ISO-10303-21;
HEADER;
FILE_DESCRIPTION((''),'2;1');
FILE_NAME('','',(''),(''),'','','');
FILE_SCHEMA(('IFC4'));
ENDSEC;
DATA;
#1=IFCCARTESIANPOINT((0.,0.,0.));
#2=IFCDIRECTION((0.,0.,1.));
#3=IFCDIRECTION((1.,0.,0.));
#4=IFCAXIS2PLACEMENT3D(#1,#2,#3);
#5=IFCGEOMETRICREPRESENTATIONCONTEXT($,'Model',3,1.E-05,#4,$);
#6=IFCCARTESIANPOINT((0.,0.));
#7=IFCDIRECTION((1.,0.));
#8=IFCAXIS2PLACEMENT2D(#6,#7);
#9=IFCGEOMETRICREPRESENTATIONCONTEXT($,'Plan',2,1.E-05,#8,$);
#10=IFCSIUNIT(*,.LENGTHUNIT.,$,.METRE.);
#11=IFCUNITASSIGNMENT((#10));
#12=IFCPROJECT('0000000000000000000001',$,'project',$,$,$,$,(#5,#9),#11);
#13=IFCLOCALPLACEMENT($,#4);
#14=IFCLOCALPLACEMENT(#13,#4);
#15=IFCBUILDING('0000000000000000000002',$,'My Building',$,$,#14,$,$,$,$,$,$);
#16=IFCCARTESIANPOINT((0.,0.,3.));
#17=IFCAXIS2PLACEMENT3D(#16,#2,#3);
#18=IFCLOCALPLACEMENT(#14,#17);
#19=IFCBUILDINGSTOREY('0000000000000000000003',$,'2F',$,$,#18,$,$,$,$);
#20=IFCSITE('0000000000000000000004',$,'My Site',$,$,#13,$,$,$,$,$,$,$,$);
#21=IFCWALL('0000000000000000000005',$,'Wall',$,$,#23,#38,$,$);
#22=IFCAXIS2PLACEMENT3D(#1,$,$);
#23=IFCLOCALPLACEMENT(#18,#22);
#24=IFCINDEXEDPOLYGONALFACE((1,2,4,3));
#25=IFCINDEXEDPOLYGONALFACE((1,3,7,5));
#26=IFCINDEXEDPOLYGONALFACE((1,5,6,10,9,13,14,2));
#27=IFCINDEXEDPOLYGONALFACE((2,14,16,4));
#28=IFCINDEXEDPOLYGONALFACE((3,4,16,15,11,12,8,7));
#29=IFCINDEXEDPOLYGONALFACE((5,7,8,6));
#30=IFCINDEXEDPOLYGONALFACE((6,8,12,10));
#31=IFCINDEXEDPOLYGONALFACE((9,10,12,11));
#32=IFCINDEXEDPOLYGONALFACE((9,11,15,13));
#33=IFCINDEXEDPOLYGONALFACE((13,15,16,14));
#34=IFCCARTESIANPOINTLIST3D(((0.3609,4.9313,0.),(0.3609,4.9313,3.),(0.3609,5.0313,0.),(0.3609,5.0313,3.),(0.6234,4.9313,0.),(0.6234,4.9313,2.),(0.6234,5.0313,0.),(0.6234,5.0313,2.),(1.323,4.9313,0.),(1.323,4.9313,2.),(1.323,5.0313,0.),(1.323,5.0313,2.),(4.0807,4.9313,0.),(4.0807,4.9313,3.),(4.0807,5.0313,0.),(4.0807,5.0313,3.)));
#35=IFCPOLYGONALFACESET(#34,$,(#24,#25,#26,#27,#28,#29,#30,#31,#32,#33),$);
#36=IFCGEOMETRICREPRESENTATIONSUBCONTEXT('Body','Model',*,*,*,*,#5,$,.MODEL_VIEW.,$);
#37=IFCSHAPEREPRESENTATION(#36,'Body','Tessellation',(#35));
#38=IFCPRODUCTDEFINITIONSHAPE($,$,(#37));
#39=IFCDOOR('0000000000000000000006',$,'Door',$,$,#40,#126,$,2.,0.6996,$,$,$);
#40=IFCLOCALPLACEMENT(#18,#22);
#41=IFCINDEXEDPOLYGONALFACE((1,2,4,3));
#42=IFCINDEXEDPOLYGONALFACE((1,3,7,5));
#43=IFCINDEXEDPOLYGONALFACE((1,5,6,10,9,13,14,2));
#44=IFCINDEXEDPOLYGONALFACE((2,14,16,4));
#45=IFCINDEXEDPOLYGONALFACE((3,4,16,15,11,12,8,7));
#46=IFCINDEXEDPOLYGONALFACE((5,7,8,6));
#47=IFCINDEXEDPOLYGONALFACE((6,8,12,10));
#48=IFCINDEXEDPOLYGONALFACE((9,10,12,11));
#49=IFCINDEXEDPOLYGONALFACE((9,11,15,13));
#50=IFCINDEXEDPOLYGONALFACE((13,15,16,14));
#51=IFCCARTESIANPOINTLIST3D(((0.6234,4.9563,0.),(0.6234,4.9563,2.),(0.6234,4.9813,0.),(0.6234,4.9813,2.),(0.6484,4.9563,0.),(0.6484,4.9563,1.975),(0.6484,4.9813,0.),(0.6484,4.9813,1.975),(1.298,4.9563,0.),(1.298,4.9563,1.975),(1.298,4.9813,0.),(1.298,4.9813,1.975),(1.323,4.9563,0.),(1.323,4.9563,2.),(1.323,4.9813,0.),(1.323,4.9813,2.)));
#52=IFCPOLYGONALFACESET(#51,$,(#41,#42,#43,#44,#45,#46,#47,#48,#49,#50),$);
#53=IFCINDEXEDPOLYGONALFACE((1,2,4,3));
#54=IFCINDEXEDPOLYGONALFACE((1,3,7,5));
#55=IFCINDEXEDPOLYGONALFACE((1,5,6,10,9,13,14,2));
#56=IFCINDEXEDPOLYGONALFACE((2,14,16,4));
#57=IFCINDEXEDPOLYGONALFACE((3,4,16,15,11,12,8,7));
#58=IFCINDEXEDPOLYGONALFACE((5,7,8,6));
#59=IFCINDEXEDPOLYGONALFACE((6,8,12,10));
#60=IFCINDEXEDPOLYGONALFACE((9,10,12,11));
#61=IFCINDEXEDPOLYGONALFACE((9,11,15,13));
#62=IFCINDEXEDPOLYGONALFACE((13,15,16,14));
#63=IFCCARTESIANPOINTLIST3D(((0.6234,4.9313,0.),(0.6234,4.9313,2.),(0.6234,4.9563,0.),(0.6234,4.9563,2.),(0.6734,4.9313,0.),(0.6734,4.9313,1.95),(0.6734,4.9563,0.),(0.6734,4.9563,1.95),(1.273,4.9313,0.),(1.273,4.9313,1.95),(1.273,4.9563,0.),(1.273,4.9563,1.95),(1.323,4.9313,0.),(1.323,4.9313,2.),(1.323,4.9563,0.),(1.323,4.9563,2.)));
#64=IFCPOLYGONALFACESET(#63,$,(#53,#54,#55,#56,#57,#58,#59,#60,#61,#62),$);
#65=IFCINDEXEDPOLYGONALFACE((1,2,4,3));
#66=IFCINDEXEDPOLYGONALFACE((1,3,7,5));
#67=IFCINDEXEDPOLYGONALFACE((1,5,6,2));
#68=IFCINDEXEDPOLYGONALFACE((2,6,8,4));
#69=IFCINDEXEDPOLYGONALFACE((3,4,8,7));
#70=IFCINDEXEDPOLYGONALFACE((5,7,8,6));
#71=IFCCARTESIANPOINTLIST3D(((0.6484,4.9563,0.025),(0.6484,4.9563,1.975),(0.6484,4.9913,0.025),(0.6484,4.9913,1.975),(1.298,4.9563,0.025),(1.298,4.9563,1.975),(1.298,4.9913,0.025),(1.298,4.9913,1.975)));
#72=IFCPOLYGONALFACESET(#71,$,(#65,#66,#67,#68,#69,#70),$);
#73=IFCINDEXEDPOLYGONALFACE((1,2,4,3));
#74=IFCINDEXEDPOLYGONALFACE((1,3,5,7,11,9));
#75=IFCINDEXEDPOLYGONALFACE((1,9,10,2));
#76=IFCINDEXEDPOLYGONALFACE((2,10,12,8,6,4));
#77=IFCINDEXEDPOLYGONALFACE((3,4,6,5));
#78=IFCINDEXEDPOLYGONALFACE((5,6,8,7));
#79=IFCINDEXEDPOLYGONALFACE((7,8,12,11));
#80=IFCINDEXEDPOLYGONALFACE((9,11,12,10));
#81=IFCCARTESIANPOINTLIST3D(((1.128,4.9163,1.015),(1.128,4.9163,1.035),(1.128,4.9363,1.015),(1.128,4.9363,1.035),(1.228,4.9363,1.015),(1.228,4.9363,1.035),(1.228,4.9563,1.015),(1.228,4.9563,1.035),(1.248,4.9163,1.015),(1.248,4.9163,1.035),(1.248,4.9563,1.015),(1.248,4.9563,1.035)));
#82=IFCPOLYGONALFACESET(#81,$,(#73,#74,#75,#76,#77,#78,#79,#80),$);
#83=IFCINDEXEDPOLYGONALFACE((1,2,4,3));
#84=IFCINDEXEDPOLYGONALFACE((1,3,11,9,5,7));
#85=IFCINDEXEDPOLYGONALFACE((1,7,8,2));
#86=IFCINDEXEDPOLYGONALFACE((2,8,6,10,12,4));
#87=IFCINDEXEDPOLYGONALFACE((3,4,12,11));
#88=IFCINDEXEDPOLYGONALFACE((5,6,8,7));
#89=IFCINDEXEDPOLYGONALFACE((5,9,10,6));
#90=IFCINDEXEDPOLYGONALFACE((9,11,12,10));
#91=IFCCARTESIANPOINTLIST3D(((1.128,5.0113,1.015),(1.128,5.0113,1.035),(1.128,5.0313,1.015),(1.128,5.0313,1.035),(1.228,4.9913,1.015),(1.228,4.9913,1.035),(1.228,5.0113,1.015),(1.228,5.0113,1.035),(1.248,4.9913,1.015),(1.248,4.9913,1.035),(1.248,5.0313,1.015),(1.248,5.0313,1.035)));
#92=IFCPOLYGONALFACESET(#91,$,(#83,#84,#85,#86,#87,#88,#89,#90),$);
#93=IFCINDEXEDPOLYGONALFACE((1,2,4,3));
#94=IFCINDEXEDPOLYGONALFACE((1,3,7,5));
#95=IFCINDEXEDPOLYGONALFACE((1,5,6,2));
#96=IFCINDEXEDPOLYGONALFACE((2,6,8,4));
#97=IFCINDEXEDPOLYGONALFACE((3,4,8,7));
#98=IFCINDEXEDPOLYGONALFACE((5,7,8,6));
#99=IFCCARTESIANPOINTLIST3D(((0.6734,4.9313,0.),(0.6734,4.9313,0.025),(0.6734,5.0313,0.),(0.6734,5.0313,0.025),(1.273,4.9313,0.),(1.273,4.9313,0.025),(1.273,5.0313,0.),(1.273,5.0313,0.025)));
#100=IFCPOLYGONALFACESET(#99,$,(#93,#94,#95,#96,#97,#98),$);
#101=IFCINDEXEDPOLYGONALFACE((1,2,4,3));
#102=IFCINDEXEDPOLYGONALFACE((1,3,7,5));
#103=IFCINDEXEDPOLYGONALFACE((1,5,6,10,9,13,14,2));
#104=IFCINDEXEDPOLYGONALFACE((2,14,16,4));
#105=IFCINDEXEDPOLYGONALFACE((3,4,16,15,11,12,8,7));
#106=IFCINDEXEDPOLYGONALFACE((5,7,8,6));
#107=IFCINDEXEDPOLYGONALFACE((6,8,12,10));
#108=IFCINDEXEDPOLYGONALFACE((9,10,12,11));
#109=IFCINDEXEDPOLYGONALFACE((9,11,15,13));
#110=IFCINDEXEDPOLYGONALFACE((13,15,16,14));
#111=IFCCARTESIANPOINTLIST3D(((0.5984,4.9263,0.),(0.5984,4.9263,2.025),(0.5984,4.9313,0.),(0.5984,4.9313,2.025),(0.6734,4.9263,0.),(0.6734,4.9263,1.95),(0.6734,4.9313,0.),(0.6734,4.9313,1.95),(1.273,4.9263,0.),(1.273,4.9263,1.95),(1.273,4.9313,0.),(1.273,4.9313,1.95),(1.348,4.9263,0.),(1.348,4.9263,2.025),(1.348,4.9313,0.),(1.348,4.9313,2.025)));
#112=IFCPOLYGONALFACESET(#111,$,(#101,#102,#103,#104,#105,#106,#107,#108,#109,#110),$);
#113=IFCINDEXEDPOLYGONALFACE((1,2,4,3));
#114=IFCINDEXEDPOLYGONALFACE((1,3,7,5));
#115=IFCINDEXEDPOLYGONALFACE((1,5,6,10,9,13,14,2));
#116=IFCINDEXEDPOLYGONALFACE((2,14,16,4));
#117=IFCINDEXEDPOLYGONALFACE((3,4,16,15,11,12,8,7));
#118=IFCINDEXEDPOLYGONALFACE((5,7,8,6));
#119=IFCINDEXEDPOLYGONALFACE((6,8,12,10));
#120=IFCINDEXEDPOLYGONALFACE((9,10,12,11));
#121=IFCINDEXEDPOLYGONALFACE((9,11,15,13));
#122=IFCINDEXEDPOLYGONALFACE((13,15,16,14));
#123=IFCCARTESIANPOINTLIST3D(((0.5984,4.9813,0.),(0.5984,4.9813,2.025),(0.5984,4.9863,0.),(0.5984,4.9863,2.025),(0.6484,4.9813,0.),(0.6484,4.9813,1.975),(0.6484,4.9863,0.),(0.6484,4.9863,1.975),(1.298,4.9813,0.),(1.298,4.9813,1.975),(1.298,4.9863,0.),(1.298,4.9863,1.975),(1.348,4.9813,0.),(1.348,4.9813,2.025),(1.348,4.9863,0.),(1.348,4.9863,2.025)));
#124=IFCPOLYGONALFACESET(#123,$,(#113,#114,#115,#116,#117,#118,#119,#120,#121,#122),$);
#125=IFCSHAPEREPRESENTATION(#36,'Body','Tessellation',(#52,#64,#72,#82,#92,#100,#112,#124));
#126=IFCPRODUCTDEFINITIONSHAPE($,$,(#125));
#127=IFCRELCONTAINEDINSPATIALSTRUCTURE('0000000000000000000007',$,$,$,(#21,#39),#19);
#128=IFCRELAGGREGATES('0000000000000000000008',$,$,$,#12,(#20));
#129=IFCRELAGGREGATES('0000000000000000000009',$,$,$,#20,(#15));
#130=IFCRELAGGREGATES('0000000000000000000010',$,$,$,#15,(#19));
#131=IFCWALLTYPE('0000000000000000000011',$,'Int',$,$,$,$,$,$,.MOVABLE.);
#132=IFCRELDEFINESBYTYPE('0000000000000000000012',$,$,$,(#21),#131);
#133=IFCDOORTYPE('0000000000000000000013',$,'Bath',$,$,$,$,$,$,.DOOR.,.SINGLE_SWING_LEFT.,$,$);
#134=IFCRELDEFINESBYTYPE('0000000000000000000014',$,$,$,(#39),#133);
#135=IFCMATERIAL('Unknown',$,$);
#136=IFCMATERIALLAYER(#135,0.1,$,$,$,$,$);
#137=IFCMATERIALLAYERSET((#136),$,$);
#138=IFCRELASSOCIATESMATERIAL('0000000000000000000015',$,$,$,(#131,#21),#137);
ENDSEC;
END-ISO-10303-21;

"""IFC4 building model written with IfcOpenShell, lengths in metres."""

from ifc_helpers import new_model, entity, si_unit, frame, origin_with_axes, origin_2d_with_axis, place, context, subcontext, project, spatial, line, indexed_curve, outline, extrude, shape, source, transform, mapped, material, layer, layer_set, layer_usage, type_object, type_shapes, element, fill, save


model = new_model("IFC4")

# Units and contexts
model_context = context("Model", 3, precision=1e-05, world=origin_with_axes())
plan_context = context("Plan", 2, precision=1e-05, world=origin_2d_with_axis())
body_context_1 = subcontext(model_context, "Body", "Model", "MODEL_VIEW")
body_context_2 = subcontext(plan_context, "Body", "Plan", "PLAN_VIEW")
ifc_project = project(units=[si_unit("LENGTHUNIT", "METRE")], contexts=[model_context, plan_context])

# Site, building, storey
site_placement = place(None, origin_with_axes())
site = spatial("IfcSite", under=ifc_project, at=site_placement, Name="My Site")
building_placement = place(site_placement, origin_with_axes())
building = spatial("IfcBuilding", under=site, at=building_placement, Name="My Building")
storey_placement = place(building_placement, frame((0.0, 0.0, 3.0), z_axis=(0.0, 0.0, 1.0), x_axis=(1.0, 0.0, 0.0)))
storey = spatial("IfcBuildingStorey", under=building, at=storey_placement, Name="2F")

# Shared definitions
ifc_material = material(Name="Unknown")

# Shared definitions
ifc_layer_1 = layer(ifc_material, 0.1)
ifc_layer_set_1 = layer_set([ifc_layer_1])
wall_type_1 = type_object("IfcWallType", Name="Int", PredefinedType="MOVABLE", material=ifc_layer_set_1)

# Wall, opening, door
ifc_layer_usage_1 = layer_usage(ifc_layer_set_1, "AXIS2", "POSITIVE", 0.0)
wall_1_placement = place(storey_placement, frame((4.0807, 5.0313, 0.0), z_axis=(0.0, 0.0, 1.0), x_axis=(-1.0, 0.0, 0.0)))
wall_1 = element("IfcWall", 1, at=wall_1_placement, inside=storey, type_object=wall_type_1, material=ifc_layer_usage_1, Name="Wall", context=body_context_1, shape_type="SweptSolid", body=[
    extrude(outline(indexed_curve([(0.0, 0.0), (0.0, 0.1), (3.7198, 0.1), (3.7198, 0.0)], segments=[line(1, 2, 3, 4, 1)])), origin_with_axes(), (0.0, 0.0, 1.0), 3.0),
])
shared_shape_1 = source(origin_with_axes(), body_context_1, "Body", "SweptSolid", [
    extrude(outline(indexed_curve([(0.0, 0.0), (0.6996, 0.0), (0.6996, 2.0), (0.0, 2.0)], segments=[line(1, 2, 3, 4, 1)])), frame((0.0, -0.6, 0.0), z_axis=(0.0, -1.0, 0.0), x_axis=(1.0, 0.0, 0.0)), (0.0, 0.0, -1.0), 1.2),
])
opening_1_placement = place(wall_1_placement, frame((3.4573, 0.1, 0.0), z_axis=(0.0, 0.0, 1.0), x_axis=(-1.0, 0.0, 0.0)))
opening_1 = element("IfcOpeningElement", 2, at=opening_1_placement, cuts=wall_1, PredefinedType="OPENING", context=body_context_1, shape_type="MappedRepresentation", body=[
    mapped(shared_shape_1, transform((0.0, 0.0, 0.0), x_axis=(1.0, 0.0, 0.0), y_axis=(0.0, 1.0, 0.0), z_axis=(0.0, 0.0, 1.0), scale=1.0)),
])
door_type_1 = type_object("IfcDoorType", Name="Bath", OperationType="SINGLE_SWING_LEFT", PredefinedType="DOOR")
shared_shape_2 = source(origin_with_axes(), body_context_1, "Body", "SweptSolid", [
    extrude(outline(indexed_curve([(0.025, 0.0), (0.025, 1.975), (0.6746, 1.975), (0.6746, 0.0), (0.6996, 0.0), (0.6996, 2.0), (0.0, 2.0), (0.0, 0.0), (0.025, 0.0)])), frame((0.0, 0.025, 0.0), z_axis=(0.0, -1.0, 0.0), x_axis=(1.0, 0.0, 0.0)), (0.0, 0.0, -1.0), 0.025),
    extrude(outline(indexed_curve([(0.0, 0.0), (0.0, 2.0), (0.6996, 2.0), (0.6996, 0.0), (0.6496, 0.0), (0.6496, 1.95), (0.05, 1.95), (0.05, 0.0)], segments=[line(1, 2, 3, 4, 5, 6, 7, 8, 1)])), frame((0.0, 0.0, 0.0), z_axis=(0.0, -1.0, 0.0), x_axis=(1.0, 0.0, 0.0)), (0.0, 0.0, -1.0), 0.025),
    extrude(outline(indexed_curve([(0.0, 0.0), (0.6496, 0.0), (0.6496, 0.035), (0.0, 0.035)], segments=[line(1, 2, 3, 4, 1)])), frame((0.025, 0.025, 0.025), z_axis=(0.0, 0.0, 1.0), x_axis=(1.0, 0.0, 0.0)), (0.0, 0.0, 1.0), 1.95),
    extrude(outline(indexed_curve([(0.0, 0.0), (0.0, -0.04), (-0.12, -0.04), (-0.12, -0.02), (-0.02, -0.02), (-0.02, 0.0)], segments=[line(1, 2, 3, 4, 5, 6, 1)])), frame((0.6246, 0.025, 1.015), z_axis=(0.0, 0.0, 1.0), x_axis=(1.0, 0.0, 0.0)), (0.0, 0.0, 1.0), 0.02),
    extrude(outline(indexed_curve([(0.0, 0.0), (0.0, 0.04), (-0.12, 0.04), (-0.12, 0.02), (-0.02, 0.02), (-0.02, 0.0)], segments=[line(1, 2, 3, 4, 5, 6, 1)])), frame((0.6246, 0.06, 1.015), z_axis=(0.0, 0.0, 1.0), x_axis=(1.0, 0.0, 0.0)), (0.0, 0.0, 1.0), 0.02),
    extrude(outline(indexed_curve([(0.0, 0.0), (0.5996, 0.0), (0.5996, 0.1), (0.0, 0.1)], segments=[line(1, 2, 3, 4, 1)])), frame((0.05, 0.0, 0.0), z_axis=(0.0, 0.0, 1.0), x_axis=(1.0, 0.0, 0.0)), (0.0, 0.0, 1.0), 0.025),
    extrude(outline(indexed_curve([(0.0, 0.0), (0.0, 2.025), (0.7496, 2.025), (0.7496, 0.0), (0.6746, 0.0), (0.6746, 1.95), (0.075, 1.95), (0.075, 0.0)], segments=[line(1, 2, 3, 4, 5, 6, 7, 8, 1)])), frame((-0.025, -0.005, 0.0), z_axis=(0.0, -1.0, 0.0), x_axis=(1.0, 0.0, 0.0)), (0.0, 0.0, -1.0), 0.005),
    extrude(outline(indexed_curve([(0.0, 0.0), (0.0, 2.025), (0.7496, 2.025), (0.7496, 0.0), (0.6996, 0.0), (0.6996, 1.975), (0.05, 1.975), (0.05, 0.0)], segments=[line(1, 2, 3, 4, 5, 6, 7, 8, 1)])), frame((-0.025, 0.05, 0.0), z_axis=(0.0, -1.0, 0.0), x_axis=(1.0, 0.0, 0.0)), (0.0, 0.0, -1.0), 0.005),
])
shared_shape_3 = source(origin_with_axes(), body_context_2, "Body", "Curve2D", [
    entity("IfcIndexedPolyCurve", entity("IfcCartesianPointList2D", [[0.0, 0.0], [0.0, 0.05], [0.025, 0.05], [0.025, 0.025], [0.05, 0.025], [0.05, 0.0]]), [entity("IfcLineIndex", [1, 2, 3, 4, 5, 6, 1])]),
    entity("IfcIndexedPolyCurve", entity("IfcCartesianPointList2D", [[0.6996, 0.0], [0.6996, 0.05], [0.6746, 0.05], [0.6746, 0.025], [0.6496, 0.025], [0.6496, 0.0]]), [entity("IfcLineIndex", [1, 2, 3, 4, 5, 6, 1])]),
    entity("IfcTrimmedCurve", entity("IfcEllipse", entity("IfcAxis2Placement2D", entity("IfcCartesianPoint", [0.06, 0.05]), entity("IfcDirection", [1.0, 0.0])), 0.6146, 0.6496), [entity("IfcCartesianPoint", [0.6746, 0.05])], [entity("IfcCartesianPoint", [0.06, 0.6996])], True, "CARTESIAN"),
    entity("IfcIndexedPolyCurve", entity("IfcCartesianPointList2D", [[0.025, 0.05], [0.06, 0.05], [0.06, 0.6996], [0.025, 0.6996]]), [entity("IfcLineIndex", [1, 2, 3, 4, 1])]),
])
type_shapes(door_type_1, [shared_shape_2, shared_shape_3])
door_1_placement = place(opening_1_placement, frame((0.0, 0.0, 0.0), z_axis=(0.0, 0.0, 1.0), x_axis=(1.0, 0.0, 0.0)))
door_1 = element("IfcDoor", 3, at=door_1_placement, inside=storey, type_object=door_type_1, Name="Door", OverallHeight=2.0, OverallWidth=0.6996, shapes=[
    shape(body_context_1, "Body", "MappedRepresentation", [mapped(shared_shape_2, transform((0.0, 0.0, 0.0), x_axis=(1.0, 0.0, 0.0), y_axis=(0.0, 1.0, 0.0), z_axis=(0.0, 0.0, 1.0), scale=1.0))]),
    shape(body_context_2, "Body", "MappedRepresentation", [mapped(shared_shape_3, transform((0.0, 0.0, 0.0), x_axis=(1.0, 0.0, 0.0), y_axis=(0.0, 1.0, 0.0), z_axis=(0.0, 0.0, 1.0), scale=1.0))]),
])
fill(opening_1, door_1)

save(model, "model.ifc")
